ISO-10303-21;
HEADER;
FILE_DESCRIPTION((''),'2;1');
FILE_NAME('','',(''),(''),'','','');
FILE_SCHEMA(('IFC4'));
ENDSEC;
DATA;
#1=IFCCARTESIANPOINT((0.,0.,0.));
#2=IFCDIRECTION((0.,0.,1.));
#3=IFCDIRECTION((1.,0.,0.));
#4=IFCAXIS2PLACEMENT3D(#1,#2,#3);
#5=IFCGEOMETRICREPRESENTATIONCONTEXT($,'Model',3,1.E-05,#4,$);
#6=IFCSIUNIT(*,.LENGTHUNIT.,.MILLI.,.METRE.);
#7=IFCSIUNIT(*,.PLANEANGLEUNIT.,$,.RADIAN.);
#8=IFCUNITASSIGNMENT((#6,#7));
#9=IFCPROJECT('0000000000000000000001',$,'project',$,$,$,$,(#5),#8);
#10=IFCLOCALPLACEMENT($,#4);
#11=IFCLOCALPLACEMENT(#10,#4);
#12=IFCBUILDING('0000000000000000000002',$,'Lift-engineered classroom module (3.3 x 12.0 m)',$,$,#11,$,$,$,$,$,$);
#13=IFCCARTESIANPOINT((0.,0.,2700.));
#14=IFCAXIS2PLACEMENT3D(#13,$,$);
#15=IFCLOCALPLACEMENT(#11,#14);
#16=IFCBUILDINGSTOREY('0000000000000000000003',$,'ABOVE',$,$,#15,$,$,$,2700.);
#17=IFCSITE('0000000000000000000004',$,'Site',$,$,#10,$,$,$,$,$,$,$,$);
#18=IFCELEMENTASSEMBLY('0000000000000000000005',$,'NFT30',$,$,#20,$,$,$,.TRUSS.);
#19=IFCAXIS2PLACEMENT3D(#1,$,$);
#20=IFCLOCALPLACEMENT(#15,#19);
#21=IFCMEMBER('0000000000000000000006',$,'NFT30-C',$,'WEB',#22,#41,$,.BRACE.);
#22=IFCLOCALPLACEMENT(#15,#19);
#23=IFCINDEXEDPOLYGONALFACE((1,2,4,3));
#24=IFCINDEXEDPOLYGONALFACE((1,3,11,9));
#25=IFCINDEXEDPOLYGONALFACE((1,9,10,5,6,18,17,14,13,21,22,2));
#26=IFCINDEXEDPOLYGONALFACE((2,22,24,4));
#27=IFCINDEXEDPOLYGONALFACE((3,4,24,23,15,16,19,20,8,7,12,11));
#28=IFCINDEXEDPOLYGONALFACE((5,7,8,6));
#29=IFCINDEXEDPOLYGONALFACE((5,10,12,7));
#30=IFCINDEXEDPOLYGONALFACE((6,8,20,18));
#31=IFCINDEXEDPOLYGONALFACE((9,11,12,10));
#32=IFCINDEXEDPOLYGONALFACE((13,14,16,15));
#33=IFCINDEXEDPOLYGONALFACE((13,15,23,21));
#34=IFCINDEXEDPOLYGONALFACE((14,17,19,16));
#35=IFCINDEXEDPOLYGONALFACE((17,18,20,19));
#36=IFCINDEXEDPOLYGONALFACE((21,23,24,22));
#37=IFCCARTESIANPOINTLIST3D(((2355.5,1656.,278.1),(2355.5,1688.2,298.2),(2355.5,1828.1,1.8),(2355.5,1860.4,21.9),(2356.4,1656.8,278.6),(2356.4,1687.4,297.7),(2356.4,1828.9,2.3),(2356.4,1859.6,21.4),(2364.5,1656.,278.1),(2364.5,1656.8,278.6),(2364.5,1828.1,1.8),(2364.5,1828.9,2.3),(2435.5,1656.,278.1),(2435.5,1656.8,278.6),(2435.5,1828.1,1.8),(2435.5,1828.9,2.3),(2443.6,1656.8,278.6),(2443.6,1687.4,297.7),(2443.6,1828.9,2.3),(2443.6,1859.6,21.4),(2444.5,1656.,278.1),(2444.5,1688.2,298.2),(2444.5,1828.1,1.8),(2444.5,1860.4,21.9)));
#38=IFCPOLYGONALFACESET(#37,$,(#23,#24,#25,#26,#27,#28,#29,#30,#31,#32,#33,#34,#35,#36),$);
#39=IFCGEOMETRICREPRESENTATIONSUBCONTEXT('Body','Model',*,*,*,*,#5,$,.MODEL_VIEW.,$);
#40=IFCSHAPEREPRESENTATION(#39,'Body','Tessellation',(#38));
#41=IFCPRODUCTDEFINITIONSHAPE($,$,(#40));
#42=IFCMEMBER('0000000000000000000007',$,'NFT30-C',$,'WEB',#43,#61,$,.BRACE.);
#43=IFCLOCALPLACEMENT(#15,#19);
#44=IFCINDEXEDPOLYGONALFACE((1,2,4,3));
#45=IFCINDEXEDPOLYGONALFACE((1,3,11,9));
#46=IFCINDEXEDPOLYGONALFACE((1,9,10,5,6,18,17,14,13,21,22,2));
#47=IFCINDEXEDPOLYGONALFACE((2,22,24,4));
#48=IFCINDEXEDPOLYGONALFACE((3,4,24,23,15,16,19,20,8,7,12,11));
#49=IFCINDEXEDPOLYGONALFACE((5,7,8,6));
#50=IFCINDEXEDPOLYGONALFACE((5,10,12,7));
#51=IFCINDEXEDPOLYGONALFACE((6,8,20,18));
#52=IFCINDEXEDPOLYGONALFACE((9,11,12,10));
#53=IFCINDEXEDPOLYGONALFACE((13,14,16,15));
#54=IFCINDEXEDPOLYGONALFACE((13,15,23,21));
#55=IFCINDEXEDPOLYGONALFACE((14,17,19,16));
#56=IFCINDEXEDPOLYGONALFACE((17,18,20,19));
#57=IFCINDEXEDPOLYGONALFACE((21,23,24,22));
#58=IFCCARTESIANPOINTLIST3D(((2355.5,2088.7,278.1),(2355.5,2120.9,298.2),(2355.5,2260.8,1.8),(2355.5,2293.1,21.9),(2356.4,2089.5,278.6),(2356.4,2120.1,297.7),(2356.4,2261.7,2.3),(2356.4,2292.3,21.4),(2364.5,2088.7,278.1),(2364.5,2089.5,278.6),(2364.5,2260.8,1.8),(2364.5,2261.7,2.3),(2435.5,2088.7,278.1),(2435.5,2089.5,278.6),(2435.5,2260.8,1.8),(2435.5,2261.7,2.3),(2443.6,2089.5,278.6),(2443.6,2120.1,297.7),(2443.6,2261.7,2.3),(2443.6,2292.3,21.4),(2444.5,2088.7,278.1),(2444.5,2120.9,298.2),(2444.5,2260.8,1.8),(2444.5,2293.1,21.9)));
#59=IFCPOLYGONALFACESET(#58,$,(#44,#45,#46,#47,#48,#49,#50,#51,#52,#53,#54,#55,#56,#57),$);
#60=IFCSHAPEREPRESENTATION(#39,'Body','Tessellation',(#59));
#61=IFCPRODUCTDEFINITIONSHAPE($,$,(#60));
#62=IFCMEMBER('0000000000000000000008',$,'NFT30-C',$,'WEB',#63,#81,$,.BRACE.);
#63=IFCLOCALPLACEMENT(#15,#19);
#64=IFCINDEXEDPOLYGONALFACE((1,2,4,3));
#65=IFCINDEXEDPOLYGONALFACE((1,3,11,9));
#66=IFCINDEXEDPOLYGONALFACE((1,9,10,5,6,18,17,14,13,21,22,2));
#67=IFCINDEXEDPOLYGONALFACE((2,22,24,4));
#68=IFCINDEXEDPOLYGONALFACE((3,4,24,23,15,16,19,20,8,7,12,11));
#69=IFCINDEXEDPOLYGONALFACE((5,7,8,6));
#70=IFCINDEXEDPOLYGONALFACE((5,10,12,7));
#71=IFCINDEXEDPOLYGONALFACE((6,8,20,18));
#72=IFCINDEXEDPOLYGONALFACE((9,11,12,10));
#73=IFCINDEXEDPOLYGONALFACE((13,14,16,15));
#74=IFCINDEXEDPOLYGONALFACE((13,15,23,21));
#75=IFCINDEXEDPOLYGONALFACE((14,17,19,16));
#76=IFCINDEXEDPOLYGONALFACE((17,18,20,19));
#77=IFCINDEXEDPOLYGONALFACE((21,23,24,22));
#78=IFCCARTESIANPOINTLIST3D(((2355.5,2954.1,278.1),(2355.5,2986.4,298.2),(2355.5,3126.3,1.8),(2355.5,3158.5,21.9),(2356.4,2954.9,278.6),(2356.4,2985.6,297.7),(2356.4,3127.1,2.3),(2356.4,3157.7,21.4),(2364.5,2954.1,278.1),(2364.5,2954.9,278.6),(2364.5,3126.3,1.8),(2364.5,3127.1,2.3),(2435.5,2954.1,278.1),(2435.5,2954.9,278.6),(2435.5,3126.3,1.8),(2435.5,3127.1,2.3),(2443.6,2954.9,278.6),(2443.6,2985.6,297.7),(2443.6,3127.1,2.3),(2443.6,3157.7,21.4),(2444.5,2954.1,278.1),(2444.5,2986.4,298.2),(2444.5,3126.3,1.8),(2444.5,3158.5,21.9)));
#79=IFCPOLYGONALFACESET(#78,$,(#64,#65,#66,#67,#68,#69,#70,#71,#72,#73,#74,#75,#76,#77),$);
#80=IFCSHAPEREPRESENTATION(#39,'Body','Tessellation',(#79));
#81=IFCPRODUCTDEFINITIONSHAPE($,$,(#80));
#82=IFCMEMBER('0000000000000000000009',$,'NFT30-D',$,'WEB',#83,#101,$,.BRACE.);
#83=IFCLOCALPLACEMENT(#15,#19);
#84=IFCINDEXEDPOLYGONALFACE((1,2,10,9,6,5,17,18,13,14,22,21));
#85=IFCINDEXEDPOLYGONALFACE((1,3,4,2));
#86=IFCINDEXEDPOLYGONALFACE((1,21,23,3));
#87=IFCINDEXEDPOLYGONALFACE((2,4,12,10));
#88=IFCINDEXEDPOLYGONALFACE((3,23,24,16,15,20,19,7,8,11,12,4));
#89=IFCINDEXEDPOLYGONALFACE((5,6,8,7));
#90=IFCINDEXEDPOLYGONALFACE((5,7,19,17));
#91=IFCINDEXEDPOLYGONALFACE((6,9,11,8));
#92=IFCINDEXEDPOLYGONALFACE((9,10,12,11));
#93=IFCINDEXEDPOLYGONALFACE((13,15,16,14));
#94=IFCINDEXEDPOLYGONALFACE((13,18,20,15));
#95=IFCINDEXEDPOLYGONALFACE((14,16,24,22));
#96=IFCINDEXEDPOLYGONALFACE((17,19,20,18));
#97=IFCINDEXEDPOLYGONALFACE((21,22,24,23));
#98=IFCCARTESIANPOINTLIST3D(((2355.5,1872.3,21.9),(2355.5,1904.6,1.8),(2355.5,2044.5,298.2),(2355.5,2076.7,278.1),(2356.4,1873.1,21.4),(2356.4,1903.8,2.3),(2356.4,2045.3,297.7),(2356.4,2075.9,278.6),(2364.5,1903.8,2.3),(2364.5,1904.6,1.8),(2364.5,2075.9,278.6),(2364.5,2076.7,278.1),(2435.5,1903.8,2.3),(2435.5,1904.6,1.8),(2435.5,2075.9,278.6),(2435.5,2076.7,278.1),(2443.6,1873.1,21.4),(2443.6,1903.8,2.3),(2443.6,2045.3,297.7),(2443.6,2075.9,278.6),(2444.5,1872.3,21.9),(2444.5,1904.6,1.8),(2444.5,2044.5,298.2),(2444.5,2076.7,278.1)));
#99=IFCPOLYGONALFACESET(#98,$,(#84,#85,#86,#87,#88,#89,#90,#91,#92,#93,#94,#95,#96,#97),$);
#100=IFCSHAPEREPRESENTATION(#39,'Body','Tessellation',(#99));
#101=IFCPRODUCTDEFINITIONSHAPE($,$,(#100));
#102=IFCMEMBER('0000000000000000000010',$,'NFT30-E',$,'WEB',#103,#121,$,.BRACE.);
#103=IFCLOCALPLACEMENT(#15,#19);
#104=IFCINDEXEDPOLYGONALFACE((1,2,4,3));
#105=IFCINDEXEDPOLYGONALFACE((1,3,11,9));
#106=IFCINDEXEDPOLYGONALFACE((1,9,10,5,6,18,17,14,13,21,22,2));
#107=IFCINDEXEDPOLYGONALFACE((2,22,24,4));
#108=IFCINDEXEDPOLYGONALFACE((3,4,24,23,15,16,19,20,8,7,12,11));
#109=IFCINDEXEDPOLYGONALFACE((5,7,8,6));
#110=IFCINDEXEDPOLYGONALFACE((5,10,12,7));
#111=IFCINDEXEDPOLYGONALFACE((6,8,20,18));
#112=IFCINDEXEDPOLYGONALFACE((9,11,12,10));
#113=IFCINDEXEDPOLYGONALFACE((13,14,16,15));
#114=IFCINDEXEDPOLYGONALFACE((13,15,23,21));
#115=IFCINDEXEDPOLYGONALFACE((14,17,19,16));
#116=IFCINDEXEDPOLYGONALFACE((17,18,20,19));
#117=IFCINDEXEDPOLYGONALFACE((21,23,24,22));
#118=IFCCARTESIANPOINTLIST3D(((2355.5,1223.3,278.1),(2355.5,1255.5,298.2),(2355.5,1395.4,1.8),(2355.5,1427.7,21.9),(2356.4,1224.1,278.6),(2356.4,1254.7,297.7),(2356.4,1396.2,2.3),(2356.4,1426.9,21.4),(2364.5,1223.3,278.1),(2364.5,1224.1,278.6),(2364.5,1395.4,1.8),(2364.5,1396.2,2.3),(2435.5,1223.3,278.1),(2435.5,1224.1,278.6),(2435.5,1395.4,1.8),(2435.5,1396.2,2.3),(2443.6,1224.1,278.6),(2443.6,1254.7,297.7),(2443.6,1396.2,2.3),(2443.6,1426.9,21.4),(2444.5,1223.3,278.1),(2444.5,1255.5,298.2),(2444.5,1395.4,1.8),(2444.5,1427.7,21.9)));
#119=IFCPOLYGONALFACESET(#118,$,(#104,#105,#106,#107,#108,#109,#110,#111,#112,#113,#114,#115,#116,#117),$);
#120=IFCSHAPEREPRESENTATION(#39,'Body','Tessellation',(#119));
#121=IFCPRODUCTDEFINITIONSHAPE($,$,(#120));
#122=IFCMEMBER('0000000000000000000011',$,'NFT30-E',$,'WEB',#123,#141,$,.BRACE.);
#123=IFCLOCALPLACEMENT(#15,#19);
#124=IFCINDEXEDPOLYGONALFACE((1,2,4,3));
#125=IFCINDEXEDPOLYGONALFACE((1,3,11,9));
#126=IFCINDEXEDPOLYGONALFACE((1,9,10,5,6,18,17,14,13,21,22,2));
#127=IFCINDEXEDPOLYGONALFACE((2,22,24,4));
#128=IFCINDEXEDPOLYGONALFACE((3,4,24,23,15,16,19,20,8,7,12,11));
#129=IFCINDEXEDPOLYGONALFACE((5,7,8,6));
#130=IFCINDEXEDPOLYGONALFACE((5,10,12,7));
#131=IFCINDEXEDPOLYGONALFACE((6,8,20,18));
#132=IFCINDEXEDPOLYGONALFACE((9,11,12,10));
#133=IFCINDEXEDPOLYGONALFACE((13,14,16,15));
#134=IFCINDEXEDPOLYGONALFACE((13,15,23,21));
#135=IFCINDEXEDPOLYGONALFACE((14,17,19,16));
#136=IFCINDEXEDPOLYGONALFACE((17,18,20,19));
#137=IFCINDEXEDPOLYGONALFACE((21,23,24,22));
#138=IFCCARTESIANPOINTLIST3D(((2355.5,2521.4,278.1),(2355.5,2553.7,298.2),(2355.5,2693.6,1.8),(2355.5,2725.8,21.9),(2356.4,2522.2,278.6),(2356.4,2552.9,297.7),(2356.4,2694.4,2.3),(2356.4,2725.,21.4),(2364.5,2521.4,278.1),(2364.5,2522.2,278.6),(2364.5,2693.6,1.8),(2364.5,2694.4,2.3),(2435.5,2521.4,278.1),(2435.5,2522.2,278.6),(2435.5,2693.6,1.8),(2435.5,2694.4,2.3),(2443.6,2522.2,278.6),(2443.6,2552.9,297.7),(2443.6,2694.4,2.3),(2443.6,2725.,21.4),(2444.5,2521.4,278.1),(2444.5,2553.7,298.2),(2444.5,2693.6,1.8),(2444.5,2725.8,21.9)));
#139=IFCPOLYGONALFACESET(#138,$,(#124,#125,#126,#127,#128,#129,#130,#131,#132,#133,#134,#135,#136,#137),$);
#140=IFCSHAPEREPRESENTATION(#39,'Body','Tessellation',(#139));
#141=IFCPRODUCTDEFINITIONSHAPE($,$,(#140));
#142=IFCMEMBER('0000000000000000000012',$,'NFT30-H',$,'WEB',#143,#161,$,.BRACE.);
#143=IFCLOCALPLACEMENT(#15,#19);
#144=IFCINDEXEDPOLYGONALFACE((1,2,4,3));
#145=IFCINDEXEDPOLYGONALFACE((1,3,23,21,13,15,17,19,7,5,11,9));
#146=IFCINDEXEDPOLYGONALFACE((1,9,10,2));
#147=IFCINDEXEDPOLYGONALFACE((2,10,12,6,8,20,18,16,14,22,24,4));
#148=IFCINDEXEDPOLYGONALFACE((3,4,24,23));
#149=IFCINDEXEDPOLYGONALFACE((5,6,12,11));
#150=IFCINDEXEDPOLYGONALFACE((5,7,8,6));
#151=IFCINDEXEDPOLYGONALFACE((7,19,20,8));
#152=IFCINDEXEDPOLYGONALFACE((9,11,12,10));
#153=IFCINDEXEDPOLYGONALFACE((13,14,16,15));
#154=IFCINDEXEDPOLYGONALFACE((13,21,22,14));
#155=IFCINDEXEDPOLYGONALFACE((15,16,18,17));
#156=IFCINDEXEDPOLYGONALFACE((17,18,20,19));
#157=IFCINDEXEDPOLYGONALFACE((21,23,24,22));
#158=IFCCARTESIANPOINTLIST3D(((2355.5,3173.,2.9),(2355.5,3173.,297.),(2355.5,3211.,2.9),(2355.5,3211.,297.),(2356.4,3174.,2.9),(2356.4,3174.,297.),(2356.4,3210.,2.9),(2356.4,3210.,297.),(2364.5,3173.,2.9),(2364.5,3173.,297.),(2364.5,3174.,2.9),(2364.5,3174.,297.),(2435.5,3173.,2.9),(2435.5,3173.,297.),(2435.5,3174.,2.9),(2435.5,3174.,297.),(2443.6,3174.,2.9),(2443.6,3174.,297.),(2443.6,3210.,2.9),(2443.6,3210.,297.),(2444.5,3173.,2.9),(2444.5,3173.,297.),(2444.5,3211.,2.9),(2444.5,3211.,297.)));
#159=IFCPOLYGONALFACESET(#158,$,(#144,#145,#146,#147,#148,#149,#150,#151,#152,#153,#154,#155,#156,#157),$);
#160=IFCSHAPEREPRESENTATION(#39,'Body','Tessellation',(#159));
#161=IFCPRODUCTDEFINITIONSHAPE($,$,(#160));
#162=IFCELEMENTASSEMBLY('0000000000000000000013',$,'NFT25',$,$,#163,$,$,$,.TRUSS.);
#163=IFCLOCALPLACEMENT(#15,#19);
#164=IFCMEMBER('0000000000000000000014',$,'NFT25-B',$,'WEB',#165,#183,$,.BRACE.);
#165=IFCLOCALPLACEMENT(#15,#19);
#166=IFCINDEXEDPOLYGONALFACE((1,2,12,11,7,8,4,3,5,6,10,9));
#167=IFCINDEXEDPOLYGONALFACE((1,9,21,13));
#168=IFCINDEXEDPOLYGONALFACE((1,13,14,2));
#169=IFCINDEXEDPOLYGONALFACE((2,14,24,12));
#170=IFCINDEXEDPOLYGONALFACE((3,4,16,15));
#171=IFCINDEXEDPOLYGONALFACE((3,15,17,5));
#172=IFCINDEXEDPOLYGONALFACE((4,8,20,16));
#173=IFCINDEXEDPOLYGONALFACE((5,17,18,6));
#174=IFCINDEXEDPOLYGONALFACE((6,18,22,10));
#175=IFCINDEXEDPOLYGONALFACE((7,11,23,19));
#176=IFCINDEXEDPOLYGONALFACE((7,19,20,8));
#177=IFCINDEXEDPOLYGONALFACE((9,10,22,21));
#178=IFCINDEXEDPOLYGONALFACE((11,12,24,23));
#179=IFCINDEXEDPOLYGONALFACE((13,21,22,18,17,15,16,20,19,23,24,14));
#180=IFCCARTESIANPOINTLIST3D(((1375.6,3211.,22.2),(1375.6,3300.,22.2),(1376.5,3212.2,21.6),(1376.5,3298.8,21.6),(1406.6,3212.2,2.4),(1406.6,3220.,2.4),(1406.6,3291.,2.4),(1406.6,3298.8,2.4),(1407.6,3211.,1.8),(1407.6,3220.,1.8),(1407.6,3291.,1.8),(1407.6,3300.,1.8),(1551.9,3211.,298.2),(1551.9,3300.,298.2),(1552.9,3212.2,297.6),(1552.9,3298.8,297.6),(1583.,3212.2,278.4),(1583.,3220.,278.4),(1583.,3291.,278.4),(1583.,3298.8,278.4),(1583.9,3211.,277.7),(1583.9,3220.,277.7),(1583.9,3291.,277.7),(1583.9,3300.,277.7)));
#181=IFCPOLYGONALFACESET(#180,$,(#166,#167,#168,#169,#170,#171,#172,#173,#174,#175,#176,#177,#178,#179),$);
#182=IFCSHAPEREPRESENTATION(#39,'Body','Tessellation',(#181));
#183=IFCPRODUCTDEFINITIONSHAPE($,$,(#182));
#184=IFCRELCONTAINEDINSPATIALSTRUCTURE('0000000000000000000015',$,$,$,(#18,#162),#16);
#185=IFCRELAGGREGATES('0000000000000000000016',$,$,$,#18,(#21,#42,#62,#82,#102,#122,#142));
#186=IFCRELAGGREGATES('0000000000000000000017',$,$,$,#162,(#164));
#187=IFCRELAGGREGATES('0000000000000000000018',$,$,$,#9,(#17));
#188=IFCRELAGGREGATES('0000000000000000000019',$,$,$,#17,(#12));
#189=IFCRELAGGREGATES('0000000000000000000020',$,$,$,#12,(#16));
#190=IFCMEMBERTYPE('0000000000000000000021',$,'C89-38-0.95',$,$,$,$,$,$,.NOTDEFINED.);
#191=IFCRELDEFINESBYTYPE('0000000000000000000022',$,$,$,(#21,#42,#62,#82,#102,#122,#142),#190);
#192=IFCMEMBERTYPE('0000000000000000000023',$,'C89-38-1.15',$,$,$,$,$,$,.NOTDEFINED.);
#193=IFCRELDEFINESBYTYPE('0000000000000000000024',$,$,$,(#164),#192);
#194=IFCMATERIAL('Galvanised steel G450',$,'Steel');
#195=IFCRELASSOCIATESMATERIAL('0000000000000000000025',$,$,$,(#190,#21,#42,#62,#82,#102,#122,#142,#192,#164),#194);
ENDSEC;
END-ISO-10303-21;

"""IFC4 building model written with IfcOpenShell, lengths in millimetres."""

from ifc_helpers import new_model, si_unit, frame, origin, origin_with_axes, origin_2d, place, context, subcontext, project, spatial, c_section, extrude, material, material_profile, profile_set, profile_usage, type_object, element, aggregate, save


model = new_model("IFC4")

# Units and contexts
model_context = context("Model", 3, precision=1e-05, world=origin_with_axes())
body_context = subcontext(model_context, "Body", "Model", "MODEL_VIEW")
ifc_project = project(units=[si_unit("LENGTHUNIT", "METRE", prefix="MILLI"), si_unit("PLANEANGLEUNIT", "RADIAN")], contexts=[model_context])

# Site, building, storey
site_placement = place(None, origin_with_axes())
site = spatial("IfcSite", under=ifc_project, at=site_placement, Name="Site")
building_placement = place(site_placement, origin_with_axes())
building = spatial("IfcBuilding", under=site, at=building_placement, Name="Lift-engineered classroom module (3.3 x 12.0 m)")
storey_placement = place(building_placement, frame((0.0, 0.0, 2700.0)))
storey = spatial("IfcBuildingStorey", under=building, at=storey_placement, Name="ABOVE", Elevation=2700.0)

# Element assemblies, members
ifc_material = material(Name="Galvanised steel G450", Category="Steel")
ifc_material_profile_1 = material_profile(ifc_material, c_section(Depth=89.0, Width=38.0, WallThickness=0.9, Girth=9.0, at=origin_2d()), Name="C89-38-0.95")
ifc_profile_set_1 = profile_set([ifc_material_profile_1], Name="C89-38-0.95")
ifc_profile_usage_1 = profile_usage(ifc_profile_set_1)
member_type_1 = type_object("IfcMemberType", Name="C89-38-0.95", PredefinedType="NOTDEFINED", material=ifc_profile_set_1)
assembly_1_placement = place(storey_placement, frame((2400.0, 89.0, 0.0)))
assembly_1 = element("IfcElementAssembly", 1, at=assembly_1_placement, inside=storey, Name="NFT30", PredefinedType="TRUSS")
member_1_placement = place(assembly_1_placement, frame((0.0, 1755.3, 11.8), z_axis=(0.0, -0.528797, 0.848748), x_axis=(0.0, -0.848748, -0.528797)))
member_1 = element("IfcMember", 2, at=member_1_placement, type_object=member_type_1, material=ifc_profile_usage_1, Name="NFT30-C", ObjectType="WEB", PredefinedType="BRACE", context=body_context, shape_type="SweptSolid", body=[
    extrude(c_section(Depth=89.0, Width=38.0, WallThickness=0.9, Girth=9.0, at=origin_2d()), origin(), (0.0, 0.0, 1.0), 325.6),
])
member_2_placement = place(assembly_1_placement, frame((0.0, 2188.0, 11.8), z_axis=(0.0, -0.528797, 0.848748), x_axis=(0.0, -0.848748, -0.528797)))
member_2 = element("IfcMember", 3, at=member_2_placement, type_object=member_type_1, material=ifc_profile_usage_1, Name="NFT30-C", ObjectType="WEB", PredefinedType="BRACE", context=body_context, shape_type="SweptSolid", body=[
    extrude(c_section(Depth=89.0, Width=38.0, WallThickness=0.9, Girth=9.0, at=origin_2d()), origin(), (0.0, 0.0, 1.0), 325.6),
])
member_3_placement = place(assembly_1_placement, frame((0.0, 3053.4, 11.8), z_axis=(0.0, -0.528797, 0.848748), x_axis=(0.0, -0.848748, -0.528797)))
member_3 = element("IfcMember", 4, at=member_3_placement, type_object=member_type_1, material=ifc_profile_usage_1, Name="NFT30-C", ObjectType="WEB", PredefinedType="BRACE", context=body_context, shape_type="SweptSolid", body=[
    extrude(c_section(Depth=89.0, Width=38.0, WallThickness=0.9, Girth=9.0, at=origin_2d()), origin(), (0.0, 0.0, 1.0), 325.6),
])
member_4_placement = place(assembly_1_placement, frame((0.0, 1799.5, 11.8), z_axis=(0.0, 0.528775, 0.848762), x_axis=(0.0, 0.848762, -0.528775)))
member_4 = element("IfcMember", 5, at=member_4_placement, type_object=member_type_1, material=ifc_profile_usage_1, Name="NFT30-D", ObjectType="WEB", PredefinedType="BRACE", context=body_context, shape_type="SweptSolid", body=[
    extrude(c_section(Depth=89.0, Width=38.0, WallThickness=0.9, Girth=9.0, at=origin_2d()), origin(), (0.0, 0.0, 1.0), 325.6),
])
member_5_placement = place(assembly_1_placement, frame((0.0, 1322.5, 11.8), z_axis=(0.0, -0.528775, 0.848762), x_axis=(0.0, -0.848762, -0.528775)))
member_5 = element("IfcMember", 6, at=member_5_placement, type_object=member_type_1, material=ifc_profile_usage_1, Name="NFT30-E", ObjectType="WEB", PredefinedType="BRACE", context=body_context, shape_type="SweptSolid", body=[
    extrude(c_section(Depth=89.0, Width=38.0, WallThickness=0.9, Girth=9.0, at=origin_2d()), origin(), (0.0, 0.0, 1.0), 325.6),
])
member_6_placement = place(assembly_1_placement, frame((0.0, 2620.7, 11.8), z_axis=(0.0, -0.528775, 0.848762), x_axis=(0.0, -0.848762, -0.528775)))
member_6 = element("IfcMember", 7, at=member_6_placement, type_object=member_type_1, material=ifc_profile_usage_1, Name="NFT30-E", ObjectType="WEB", PredefinedType="BRACE", context=body_context, shape_type="SweptSolid", body=[
    extrude(c_section(Depth=89.0, Width=38.0, WallThickness=0.9, Girth=9.0, at=origin_2d()), origin(), (0.0, 0.0, 1.0), 325.6),
])
member_7_placement = place(assembly_1_placement, frame((0.0, 3103.0, 2.9), z_axis=(0.0, 0.0, 1.0), x_axis=(0.0, -1.0, 0.0)))
member_7 = element("IfcMember", 8, at=member_7_placement, type_object=member_type_1, material=ifc_profile_usage_1, Name="NFT30-H", ObjectType="WEB", PredefinedType="BRACE", context=body_context, shape_type="SweptSolid", body=[
    extrude(c_section(Depth=89.0, Width=38.0, WallThickness=0.9, Girth=9.0, at=origin_2d()), origin(), (0.0, 0.0, 1.0), 294.1),
])
aggregate(assembly_1, [member_1, member_2, member_3, member_4, member_5, member_6, member_7])
assembly_2_placement = place(storey_placement, frame((0.0, 3255.5, 0.0)))
assembly_2 = element("IfcElementAssembly", 9, at=assembly_2_placement, inside=storey, Name="NFT25", PredefinedType="TRUSS")
ifc_material_profile_2 = material_profile(ifc_material, c_section(Depth=89.0, Width=38.0, WallThickness=1.1, Girth=9.0, at=origin_2d()), Name="C89-38-1.15")
ifc_profile_set_2 = profile_set([ifc_material_profile_2], Name="C89-38-1.15")
ifc_profile_usage_2 = profile_usage(ifc_profile_set_2)
member_type_2 = type_object("IfcMemberType", Name="C89-38-1.15", PredefinedType="NOTDEFINED", material=ifc_profile_set_2)
member_8_placement = place(assembly_2_placement, frame((1391.6, 0.0, 12.0), z_axis=(0.538459, 0.0, 0.842652), x_axis=(0.842652, 0.0, -0.538459)))
member_8 = element("IfcMember", 10, at=member_8_placement, type_object=member_type_2, material=ifc_profile_usage_2, Name="NFT25-B", ObjectType="WEB", PredefinedType="BRACE", context=body_context, shape_type="SweptSolid", body=[
    extrude(c_section(Depth=89.0, Width=38.0, WallThickness=1.1, Girth=9.0, at=origin_2d()), origin(), (0.0, 0.0, 1.0), 327.5),
])
aggregate(assembly_2, [member_8])

save(model, "model.ifc")
